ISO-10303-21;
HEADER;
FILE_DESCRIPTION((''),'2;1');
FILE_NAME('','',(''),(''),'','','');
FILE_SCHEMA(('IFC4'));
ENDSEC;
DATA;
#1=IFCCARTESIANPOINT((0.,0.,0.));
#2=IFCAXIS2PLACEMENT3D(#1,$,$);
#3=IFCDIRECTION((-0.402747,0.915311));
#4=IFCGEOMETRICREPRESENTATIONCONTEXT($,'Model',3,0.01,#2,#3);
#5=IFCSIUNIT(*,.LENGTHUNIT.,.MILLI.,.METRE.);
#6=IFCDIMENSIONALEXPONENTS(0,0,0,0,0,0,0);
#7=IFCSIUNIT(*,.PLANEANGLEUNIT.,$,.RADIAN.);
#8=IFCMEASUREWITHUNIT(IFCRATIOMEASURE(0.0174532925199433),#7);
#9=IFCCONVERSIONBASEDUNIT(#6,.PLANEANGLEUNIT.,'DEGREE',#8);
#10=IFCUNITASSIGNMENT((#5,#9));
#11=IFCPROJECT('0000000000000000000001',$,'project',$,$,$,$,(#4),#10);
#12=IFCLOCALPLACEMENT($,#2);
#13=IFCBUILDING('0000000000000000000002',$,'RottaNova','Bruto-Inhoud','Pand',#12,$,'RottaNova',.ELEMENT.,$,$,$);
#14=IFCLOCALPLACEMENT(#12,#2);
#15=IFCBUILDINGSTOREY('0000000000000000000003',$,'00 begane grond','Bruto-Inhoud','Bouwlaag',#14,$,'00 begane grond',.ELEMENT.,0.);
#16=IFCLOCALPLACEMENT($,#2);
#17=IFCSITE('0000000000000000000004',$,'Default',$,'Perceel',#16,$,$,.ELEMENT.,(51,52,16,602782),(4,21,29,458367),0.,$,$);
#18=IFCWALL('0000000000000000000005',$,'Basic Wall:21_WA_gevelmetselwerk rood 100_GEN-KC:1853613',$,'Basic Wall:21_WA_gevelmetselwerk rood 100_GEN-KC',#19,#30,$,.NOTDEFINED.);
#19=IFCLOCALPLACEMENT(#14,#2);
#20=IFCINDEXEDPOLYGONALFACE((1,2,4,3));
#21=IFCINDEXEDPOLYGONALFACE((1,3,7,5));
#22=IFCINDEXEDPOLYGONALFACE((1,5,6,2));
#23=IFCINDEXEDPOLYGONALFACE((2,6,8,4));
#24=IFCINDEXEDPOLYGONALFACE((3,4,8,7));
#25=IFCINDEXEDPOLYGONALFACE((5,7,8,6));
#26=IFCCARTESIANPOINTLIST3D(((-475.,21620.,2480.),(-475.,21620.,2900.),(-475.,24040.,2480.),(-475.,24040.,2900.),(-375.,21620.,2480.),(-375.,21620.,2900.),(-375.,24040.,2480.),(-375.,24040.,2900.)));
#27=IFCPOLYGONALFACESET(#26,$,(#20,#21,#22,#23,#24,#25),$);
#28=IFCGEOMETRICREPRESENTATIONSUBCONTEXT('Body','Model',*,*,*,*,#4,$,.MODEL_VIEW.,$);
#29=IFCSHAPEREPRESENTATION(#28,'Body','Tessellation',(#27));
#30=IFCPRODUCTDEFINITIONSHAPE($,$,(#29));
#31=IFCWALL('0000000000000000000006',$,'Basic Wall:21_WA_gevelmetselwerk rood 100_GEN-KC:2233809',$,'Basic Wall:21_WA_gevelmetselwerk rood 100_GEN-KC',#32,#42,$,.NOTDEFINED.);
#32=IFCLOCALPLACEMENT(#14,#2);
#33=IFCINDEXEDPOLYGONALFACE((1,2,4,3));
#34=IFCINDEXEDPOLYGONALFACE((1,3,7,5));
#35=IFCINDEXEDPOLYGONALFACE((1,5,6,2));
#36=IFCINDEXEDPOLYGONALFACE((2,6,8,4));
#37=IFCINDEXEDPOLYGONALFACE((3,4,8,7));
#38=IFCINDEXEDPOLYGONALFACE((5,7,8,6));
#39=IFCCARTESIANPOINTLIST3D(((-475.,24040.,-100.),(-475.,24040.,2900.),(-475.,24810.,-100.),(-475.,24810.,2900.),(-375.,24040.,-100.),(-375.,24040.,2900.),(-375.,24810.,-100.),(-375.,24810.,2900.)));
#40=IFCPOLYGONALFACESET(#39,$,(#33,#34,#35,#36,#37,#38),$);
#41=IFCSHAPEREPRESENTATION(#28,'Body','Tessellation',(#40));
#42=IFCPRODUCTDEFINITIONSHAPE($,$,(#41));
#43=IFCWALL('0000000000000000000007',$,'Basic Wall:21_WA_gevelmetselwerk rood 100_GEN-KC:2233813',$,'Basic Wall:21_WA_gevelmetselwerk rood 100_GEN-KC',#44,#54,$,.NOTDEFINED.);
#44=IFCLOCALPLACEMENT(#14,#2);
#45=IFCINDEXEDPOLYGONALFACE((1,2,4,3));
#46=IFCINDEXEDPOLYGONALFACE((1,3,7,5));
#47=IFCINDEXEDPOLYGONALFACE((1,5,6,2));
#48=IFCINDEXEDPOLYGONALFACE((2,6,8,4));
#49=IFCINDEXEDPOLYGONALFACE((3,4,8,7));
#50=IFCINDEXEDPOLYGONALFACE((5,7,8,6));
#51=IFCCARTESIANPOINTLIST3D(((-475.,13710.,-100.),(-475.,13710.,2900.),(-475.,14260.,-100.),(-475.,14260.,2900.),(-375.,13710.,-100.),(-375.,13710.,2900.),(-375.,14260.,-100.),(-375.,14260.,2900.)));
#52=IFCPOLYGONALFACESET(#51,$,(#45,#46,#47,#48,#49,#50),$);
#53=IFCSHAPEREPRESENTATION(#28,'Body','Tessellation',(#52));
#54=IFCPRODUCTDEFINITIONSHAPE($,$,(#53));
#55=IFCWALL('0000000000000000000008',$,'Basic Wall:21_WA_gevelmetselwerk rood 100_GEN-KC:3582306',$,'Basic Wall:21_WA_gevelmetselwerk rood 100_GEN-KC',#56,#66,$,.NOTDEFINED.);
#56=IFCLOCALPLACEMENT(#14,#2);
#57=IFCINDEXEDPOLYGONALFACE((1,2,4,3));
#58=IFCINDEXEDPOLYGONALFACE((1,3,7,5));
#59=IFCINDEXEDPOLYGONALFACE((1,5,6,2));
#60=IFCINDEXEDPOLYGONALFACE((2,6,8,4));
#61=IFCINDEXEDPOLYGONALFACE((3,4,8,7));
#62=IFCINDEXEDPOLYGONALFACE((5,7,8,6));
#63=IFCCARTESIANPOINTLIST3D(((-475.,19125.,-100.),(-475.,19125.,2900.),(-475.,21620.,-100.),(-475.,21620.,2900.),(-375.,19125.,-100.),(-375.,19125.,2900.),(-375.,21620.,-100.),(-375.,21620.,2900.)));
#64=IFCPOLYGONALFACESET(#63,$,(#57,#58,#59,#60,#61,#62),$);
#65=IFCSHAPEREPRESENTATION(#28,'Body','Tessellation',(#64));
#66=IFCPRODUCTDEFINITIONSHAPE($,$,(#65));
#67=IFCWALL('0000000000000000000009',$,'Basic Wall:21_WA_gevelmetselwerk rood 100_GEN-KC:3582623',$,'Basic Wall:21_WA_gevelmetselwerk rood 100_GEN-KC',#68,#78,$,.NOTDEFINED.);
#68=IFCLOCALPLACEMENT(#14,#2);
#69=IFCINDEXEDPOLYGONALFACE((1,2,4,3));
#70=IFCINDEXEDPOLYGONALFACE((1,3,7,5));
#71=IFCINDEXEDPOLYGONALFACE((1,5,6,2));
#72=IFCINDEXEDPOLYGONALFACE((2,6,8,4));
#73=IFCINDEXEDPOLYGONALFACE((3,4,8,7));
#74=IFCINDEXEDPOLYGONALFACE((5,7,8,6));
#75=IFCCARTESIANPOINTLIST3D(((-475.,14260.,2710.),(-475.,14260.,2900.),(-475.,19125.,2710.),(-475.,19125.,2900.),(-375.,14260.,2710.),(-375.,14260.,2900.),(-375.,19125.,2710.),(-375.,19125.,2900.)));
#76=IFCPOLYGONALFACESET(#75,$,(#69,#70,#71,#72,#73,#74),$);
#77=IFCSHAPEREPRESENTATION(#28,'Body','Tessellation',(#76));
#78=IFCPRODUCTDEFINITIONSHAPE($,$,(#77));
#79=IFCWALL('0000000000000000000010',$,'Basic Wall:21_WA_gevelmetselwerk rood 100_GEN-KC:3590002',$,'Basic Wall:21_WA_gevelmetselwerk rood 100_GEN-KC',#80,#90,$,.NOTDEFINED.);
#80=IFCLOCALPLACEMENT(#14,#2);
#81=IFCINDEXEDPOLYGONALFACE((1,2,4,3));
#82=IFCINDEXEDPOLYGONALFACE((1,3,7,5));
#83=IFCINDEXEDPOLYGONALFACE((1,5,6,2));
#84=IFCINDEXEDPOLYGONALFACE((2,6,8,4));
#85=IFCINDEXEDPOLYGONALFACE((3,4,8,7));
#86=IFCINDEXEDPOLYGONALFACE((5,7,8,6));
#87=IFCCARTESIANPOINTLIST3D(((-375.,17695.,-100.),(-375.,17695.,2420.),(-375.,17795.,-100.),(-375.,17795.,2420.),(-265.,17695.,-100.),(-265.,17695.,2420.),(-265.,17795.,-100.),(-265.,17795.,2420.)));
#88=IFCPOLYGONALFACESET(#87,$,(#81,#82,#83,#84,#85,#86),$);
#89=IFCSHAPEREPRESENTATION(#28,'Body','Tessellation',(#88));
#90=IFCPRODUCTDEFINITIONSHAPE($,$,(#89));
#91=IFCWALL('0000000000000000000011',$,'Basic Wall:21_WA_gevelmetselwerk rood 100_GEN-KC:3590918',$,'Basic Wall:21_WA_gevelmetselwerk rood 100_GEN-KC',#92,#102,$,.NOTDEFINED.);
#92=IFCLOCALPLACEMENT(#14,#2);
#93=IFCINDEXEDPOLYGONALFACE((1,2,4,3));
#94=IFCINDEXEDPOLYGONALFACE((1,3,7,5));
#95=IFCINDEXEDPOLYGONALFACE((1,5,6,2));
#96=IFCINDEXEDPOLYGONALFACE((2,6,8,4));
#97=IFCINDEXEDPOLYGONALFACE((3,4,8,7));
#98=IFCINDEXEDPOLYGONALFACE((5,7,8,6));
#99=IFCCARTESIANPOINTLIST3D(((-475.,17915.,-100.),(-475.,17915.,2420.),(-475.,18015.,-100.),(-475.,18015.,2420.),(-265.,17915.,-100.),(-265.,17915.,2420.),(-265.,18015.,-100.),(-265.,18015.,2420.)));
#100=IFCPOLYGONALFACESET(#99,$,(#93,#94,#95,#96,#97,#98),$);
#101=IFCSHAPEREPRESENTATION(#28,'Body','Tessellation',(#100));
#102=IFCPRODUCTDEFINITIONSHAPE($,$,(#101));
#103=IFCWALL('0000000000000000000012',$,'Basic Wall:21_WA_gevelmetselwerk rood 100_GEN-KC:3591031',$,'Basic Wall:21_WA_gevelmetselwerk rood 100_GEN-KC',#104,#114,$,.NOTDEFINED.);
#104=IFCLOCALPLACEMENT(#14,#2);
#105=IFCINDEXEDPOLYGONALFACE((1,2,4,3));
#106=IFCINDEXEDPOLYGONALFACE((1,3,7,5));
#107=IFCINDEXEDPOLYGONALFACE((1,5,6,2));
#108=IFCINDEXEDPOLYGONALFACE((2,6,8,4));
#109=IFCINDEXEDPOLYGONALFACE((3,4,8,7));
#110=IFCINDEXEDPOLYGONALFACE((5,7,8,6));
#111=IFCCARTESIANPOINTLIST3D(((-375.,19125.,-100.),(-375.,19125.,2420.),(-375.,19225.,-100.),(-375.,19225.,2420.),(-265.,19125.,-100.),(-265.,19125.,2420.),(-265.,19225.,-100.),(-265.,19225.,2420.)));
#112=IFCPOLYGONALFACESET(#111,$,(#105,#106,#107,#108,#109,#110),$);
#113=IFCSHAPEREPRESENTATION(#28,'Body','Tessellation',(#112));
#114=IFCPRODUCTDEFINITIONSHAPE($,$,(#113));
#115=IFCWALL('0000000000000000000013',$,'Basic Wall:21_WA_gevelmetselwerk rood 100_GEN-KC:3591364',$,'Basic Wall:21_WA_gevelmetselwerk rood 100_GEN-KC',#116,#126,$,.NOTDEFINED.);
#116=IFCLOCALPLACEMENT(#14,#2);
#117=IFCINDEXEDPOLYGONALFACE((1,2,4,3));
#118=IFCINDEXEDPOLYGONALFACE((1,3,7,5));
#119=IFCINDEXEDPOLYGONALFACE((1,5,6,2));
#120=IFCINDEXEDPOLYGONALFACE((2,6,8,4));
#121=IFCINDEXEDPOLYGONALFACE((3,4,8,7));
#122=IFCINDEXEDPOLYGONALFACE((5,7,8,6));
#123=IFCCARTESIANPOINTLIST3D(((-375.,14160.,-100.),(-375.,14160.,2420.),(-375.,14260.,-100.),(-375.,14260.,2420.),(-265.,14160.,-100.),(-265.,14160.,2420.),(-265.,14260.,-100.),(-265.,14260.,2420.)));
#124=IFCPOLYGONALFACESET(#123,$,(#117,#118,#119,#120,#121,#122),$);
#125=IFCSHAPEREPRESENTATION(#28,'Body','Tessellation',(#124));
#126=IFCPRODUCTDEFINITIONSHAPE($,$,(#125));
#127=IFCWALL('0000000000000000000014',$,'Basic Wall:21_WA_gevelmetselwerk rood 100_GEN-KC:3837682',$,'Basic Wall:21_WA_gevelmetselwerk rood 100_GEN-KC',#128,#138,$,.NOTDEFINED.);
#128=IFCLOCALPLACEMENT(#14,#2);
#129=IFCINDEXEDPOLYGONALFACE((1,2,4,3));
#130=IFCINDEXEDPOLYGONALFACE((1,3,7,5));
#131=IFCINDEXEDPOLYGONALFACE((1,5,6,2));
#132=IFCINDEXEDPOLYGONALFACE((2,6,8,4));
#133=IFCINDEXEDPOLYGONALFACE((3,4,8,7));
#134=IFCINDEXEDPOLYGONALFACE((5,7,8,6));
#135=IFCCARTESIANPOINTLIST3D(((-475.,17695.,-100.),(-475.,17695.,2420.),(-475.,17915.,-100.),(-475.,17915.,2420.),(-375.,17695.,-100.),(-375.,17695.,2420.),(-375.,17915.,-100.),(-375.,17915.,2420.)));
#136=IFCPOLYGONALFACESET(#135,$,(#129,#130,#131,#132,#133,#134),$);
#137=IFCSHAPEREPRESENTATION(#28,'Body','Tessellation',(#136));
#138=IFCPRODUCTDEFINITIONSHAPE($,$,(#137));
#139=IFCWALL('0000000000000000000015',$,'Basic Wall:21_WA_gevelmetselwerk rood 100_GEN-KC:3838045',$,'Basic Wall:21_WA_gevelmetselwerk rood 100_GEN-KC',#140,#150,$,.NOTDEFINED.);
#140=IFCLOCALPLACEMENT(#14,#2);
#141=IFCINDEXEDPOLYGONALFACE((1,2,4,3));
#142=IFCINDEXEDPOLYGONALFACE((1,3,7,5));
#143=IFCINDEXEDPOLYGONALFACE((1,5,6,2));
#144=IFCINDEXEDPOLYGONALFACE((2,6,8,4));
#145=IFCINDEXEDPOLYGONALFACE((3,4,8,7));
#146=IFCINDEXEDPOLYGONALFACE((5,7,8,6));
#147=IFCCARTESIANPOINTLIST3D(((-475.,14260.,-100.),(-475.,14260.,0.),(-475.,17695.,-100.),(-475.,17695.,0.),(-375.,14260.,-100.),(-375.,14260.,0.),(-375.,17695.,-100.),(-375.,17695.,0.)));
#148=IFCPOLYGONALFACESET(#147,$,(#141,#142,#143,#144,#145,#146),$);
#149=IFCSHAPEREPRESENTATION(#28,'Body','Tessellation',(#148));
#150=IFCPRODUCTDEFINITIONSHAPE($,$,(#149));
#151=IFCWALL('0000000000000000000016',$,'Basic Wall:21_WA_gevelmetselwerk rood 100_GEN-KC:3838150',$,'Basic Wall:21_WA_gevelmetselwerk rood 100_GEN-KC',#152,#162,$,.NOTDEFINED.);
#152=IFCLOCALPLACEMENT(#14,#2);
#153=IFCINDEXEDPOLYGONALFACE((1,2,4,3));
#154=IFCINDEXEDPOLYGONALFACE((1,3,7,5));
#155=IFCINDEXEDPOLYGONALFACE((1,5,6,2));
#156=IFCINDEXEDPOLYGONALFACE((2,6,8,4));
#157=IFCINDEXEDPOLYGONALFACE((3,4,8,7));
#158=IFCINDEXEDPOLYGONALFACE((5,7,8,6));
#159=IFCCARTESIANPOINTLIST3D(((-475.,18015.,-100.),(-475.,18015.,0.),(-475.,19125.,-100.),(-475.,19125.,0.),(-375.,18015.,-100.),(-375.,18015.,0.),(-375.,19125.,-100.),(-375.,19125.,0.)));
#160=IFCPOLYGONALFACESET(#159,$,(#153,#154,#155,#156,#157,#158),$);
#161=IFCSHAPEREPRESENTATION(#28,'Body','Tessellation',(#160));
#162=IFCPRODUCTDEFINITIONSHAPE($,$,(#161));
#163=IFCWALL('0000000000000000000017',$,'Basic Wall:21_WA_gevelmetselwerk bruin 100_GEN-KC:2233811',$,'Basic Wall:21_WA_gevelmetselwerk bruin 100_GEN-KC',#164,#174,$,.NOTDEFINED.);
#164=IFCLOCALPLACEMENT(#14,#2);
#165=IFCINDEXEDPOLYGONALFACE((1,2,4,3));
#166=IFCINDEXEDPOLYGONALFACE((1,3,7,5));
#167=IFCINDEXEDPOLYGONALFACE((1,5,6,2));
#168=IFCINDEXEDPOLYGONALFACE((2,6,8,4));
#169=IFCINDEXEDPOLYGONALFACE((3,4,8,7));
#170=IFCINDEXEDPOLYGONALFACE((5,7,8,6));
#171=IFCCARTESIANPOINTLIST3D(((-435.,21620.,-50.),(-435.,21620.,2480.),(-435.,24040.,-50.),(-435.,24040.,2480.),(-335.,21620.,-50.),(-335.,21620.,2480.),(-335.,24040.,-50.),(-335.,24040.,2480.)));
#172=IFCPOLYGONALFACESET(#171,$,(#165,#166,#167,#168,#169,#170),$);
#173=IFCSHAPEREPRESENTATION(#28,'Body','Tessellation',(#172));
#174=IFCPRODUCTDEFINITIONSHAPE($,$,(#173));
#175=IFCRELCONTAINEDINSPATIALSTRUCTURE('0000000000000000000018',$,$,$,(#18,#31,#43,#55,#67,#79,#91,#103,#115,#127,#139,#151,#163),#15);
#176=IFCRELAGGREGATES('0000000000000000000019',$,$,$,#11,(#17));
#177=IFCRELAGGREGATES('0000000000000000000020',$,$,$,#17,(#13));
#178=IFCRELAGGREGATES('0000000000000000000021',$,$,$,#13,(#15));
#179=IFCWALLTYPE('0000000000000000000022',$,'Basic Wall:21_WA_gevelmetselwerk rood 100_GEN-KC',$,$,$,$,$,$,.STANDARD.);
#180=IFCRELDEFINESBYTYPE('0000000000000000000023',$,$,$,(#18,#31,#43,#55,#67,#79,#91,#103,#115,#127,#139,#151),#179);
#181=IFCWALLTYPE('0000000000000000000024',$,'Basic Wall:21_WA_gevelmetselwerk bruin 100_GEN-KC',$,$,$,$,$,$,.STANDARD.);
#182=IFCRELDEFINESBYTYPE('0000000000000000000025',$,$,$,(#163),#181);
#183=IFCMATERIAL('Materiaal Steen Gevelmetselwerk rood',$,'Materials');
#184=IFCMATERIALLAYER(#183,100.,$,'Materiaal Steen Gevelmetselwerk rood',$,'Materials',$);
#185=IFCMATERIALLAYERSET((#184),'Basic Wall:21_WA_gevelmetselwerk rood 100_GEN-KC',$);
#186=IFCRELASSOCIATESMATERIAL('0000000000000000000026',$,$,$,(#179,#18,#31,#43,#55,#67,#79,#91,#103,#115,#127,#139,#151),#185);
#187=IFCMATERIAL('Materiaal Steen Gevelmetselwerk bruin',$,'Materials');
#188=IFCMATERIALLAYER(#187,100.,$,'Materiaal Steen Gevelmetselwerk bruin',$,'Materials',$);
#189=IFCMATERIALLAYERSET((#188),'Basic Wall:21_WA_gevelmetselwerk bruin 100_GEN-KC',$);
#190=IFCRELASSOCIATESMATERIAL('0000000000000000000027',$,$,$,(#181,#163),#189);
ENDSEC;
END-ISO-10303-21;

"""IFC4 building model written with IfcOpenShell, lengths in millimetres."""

from ifc_helpers import new_model, entity, si_unit, converted_unit, direction, frame, frame_2d, origin, place, context, subcontext, project, spatial, polyline, rectangle, extrude, clip, bounded_halfspace, material, layer, layer_set, type_object, element, save


model = new_model("IFC4")

# Units and contexts
model_context = context("Model", 3, precision=0.01, world=origin(), true_north=direction((-0.402747, 0.915311)))
body_context = subcontext(model_context, "Body", "Model", "MODEL_VIEW")
ifc_project = project(units=[si_unit("LENGTHUNIT", "METRE", prefix="MILLI"), converted_unit("PLANEANGLEUNIT", "DEGREE", entity("IfcRatioMeasure", 0.0174532925199433), si_unit("PLANEANGLEUNIT", "RADIAN"), dimensions=[0, 0, 0, 0, 0, 0, 0])], contexts=[model_context])

# Site, building, storey
site_placement = place(None, origin())
site = spatial("IfcSite", under=ifc_project, at=site_placement, Name="Default", ObjectType="Perceel", CompositionType="ELEMENT", RefLatitude=(51, 52, 16, 602782), RefLongitude=(4, 21, 29, 458367), RefElevation=0.0)
building_placement = place(None, origin())
building = spatial("IfcBuilding", under=site, at=building_placement, Name="RottaNova", Description="Bruto-Inhoud", ObjectType="Pand", LongName="RottaNova", CompositionType="ELEMENT")
storey_placement = place(building_placement, origin())
storey = spatial("IfcBuildingStorey", under=building, at=storey_placement, Name="00 begane grond", Description="Bruto-Inhoud", ObjectType="Bouwlaag", LongName="00 begane grond", CompositionType="ELEMENT", Elevation=0.0)

# Walls
ifc_material_1 = material(Name="Materiaal Steen Gevelmetselwerk rood", Category="Materials")
ifc_layer_1 = layer(ifc_material_1, 100.0, Name="Materiaal Steen Gevelmetselwerk rood", Category="Materials")
ifc_layer_set_1 = layer_set([ifc_layer_1], Name="Basic Wall:21_WA_gevelmetselwerk rood 100_GEN-KC")
wall_type_1 = type_object("IfcWallType", Name="Basic Wall:21_WA_gevelmetselwerk rood 100_GEN-KC", PredefinedType="STANDARD", material=ifc_layer_set_1)
wall_1_placement = place(storey_placement, frame((-425.0, 24040.0, 2480.0), z_axis=(0.0, 0.0, 1.0), x_axis=(0.0, -1.0, 0.0)))
element("IfcWall", 1, at=wall_1_placement, inside=storey, type_object=wall_type_1, material=ifc_layer_set_1, Name="Basic Wall:21_WA_gevelmetselwerk rood 100_GEN-KC:1853613", ObjectType="Basic Wall:21_WA_gevelmetselwerk rood 100_GEN-KC", PredefinedType="NOTDEFINED", context=body_context, shape_type="Clipping", body=[
    clip(extrude(rectangle(XDim=2420.0, YDim=100.0, at=frame_2d((1210.0, 0.0), x_axis=(-1.0, 0.0))), origin(), (0.0, 0.0, 1.0), 420.0), bounded_halfspace(frame((2420.0, -50.0, 420.0), z_axis=(-1.0, 0.0, 0.0), x_axis=(0.0, -1.0, 0.0)), True, frame((2420.0, -50.0, 420.0), z_axis=(-1.0, 0.0, 0.0), x_axis=(0.0, -1.0, 0.0)), polyline([(0.0, 0.0), (-30480.0, 0.0), (-30480.0, -128016.0), (0.0, -128016.0), (0.0, 0.0)]))),
])
wall_2_placement = place(storey_placement, frame((-425.0, 24040.0, -100.0), z_axis=(0.0, 0.0, 1.0), x_axis=(0.0, 1.0, 0.0)))
element("IfcWall", 2, at=wall_2_placement, inside=storey, type_object=wall_type_1, material=ifc_layer_set_1, Name="Basic Wall:21_WA_gevelmetselwerk rood 100_GEN-KC:2233809", ObjectType="Basic Wall:21_WA_gevelmetselwerk rood 100_GEN-KC", PredefinedType="NOTDEFINED", context=body_context, shape_type="SweptSolid", body=[
    extrude(rectangle(XDim=770.0, YDim=100.0, at=frame_2d((385.0, 0.0), x_axis=(-1.0, 0.0))), origin(), (0.0, 0.0, 1.0), 3000.0),
])
wall_3_placement = place(storey_placement, frame((-425.0, 13710.0, -100.0), z_axis=(0.0, 0.0, 1.0), x_axis=(0.0, 1.0, 0.0)))
element("IfcWall", 3, at=wall_3_placement, inside=storey, type_object=wall_type_1, material=ifc_layer_set_1, Name="Basic Wall:21_WA_gevelmetselwerk rood 100_GEN-KC:2233813", ObjectType="Basic Wall:21_WA_gevelmetselwerk rood 100_GEN-KC", PredefinedType="NOTDEFINED", context=body_context, shape_type="SweptSolid", body=[
    extrude(rectangle(XDim=550.0, YDim=100.0, at=frame_2d((275.0, 0.0), x_axis=(-1.0, 0.0))), origin(), (0.0, 0.0, 1.0), 3000.0),
])
wall_4_placement = place(storey_placement, frame((-425.0, 19125.0, -100.0), z_axis=(0.0, 0.0, 1.0), x_axis=(0.0, 1.0, 0.0)))
element("IfcWall", 4, at=wall_4_placement, inside=storey, type_object=wall_type_1, material=ifc_layer_set_1, Name="Basic Wall:21_WA_gevelmetselwerk rood 100_GEN-KC:3582306", ObjectType="Basic Wall:21_WA_gevelmetselwerk rood 100_GEN-KC", PredefinedType="NOTDEFINED", context=body_context, shape_type="SweptSolid", body=[
    extrude(rectangle(XDim=2495.0, YDim=100.0, at=frame_2d((1247.5, 0.0), x_axis=(-1.0, 0.0))), origin(), (0.0, 0.0, 1.0), 3000.0),
])
wall_5_placement = place(storey_placement, frame((-425.0, 14260.0, 2710.0), z_axis=(0.0, 0.0, 1.0), x_axis=(0.0, 1.0, 0.0)))
element("IfcWall", 5, at=wall_5_placement, inside=storey, type_object=wall_type_1, material=ifc_layer_set_1, Name="Basic Wall:21_WA_gevelmetselwerk rood 100_GEN-KC:3582623", ObjectType="Basic Wall:21_WA_gevelmetselwerk rood 100_GEN-KC", PredefinedType="NOTDEFINED", context=body_context, shape_type="SweptSolid", body=[
    extrude(rectangle(XDim=4865.0, YDim=100.0, at=frame_2d((2432.5, 0.0), x_axis=(-1.0, 0.0))), origin(), (0.0, 0.0, 1.0), 190.0),
])
wall_6_placement = place(storey_placement, frame((-375.0, 17745.0, -100.0)))
element("IfcWall", 6, at=wall_6_placement, inside=storey, type_object=wall_type_1, material=ifc_layer_set_1, Name="Basic Wall:21_WA_gevelmetselwerk rood 100_GEN-KC:3590002", ObjectType="Basic Wall:21_WA_gevelmetselwerk rood 100_GEN-KC", PredefinedType="NOTDEFINED", context=body_context, shape_type="SweptSolid", body=[
    extrude(rectangle(XDim=110.0, YDim=100.0, at=frame_2d((55.0, 0.0), x_axis=(-1.0, 0.0))), origin(), (0.0, 0.0, 1.0), 2520.0),
])
wall_7_placement = place(storey_placement, frame((-475.0, 17965.0, -100.0)))
element("IfcWall", 7, at=wall_7_placement, inside=storey, type_object=wall_type_1, material=ifc_layer_set_1, Name="Basic Wall:21_WA_gevelmetselwerk rood 100_GEN-KC:3590918", ObjectType="Basic Wall:21_WA_gevelmetselwerk rood 100_GEN-KC", PredefinedType="NOTDEFINED", context=body_context, shape_type="SweptSolid", body=[
    extrude(rectangle(XDim=210.0, YDim=100.0, at=frame_2d((105.0, 0.0), x_axis=(-1.0, 0.0))), origin(), (0.0, 0.0, 1.0), 2520.0),
])
wall_8_placement = place(storey_placement, frame((-375.0, 19175.0, -100.0)))
element("IfcWall", 8, at=wall_8_placement, inside=storey, type_object=wall_type_1, material=ifc_layer_set_1, Name="Basic Wall:21_WA_gevelmetselwerk rood 100_GEN-KC:3591031", ObjectType="Basic Wall:21_WA_gevelmetselwerk rood 100_GEN-KC", PredefinedType="NOTDEFINED", context=body_context, shape_type="SweptSolid", body=[
    extrude(rectangle(XDim=110.0, YDim=100.0, at=frame_2d((55.0, 0.0), x_axis=(-1.0, 0.0))), origin(), (0.0, 0.0, 1.0), 2520.0),
])
wall_9_placement = place(storey_placement, frame((-375.0, 14210.0, -100.0)))
element("IfcWall", 9, at=wall_9_placement, inside=storey, type_object=wall_type_1, material=ifc_layer_set_1, Name="Basic Wall:21_WA_gevelmetselwerk rood 100_GEN-KC:3591364", ObjectType="Basic Wall:21_WA_gevelmetselwerk rood 100_GEN-KC", PredefinedType="NOTDEFINED", context=body_context, shape_type="SweptSolid", body=[
    extrude(rectangle(XDim=110.0, YDim=100.0, at=frame_2d((55.0, 0.0), x_axis=(-1.0, 0.0))), origin(), (0.0, 0.0, 1.0), 2520.0),
])
wall_10_placement = place(storey_placement, frame((-425.0, 17695.0, -100.0), z_axis=(0.0, 0.0, 1.0), x_axis=(0.0, 1.0, 0.0)))
element("IfcWall", 10, at=wall_10_placement, inside=storey, type_object=wall_type_1, material=ifc_layer_set_1, Name="Basic Wall:21_WA_gevelmetselwerk rood 100_GEN-KC:3837682", ObjectType="Basic Wall:21_WA_gevelmetselwerk rood 100_GEN-KC", PredefinedType="NOTDEFINED", context=body_context, shape_type="SweptSolid", body=[
    extrude(rectangle(XDim=220.0, YDim=100.0, at=frame_2d((110.0, 0.0), x_axis=(-1.0, 0.0))), origin(), (0.0, 0.0, 1.0), 2520.0),
])
wall_11_placement = place(storey_placement, frame((-425.0, 14260.0, -100.0), z_axis=(0.0, 0.0, 1.0), x_axis=(0.0, 1.0, 0.0)))
element("IfcWall", 11, at=wall_11_placement, inside=storey, type_object=wall_type_1, material=ifc_layer_set_1, Name="Basic Wall:21_WA_gevelmetselwerk rood 100_GEN-KC:3838045", ObjectType="Basic Wall:21_WA_gevelmetselwerk rood 100_GEN-KC", PredefinedType="NOTDEFINED", context=body_context, shape_type="SweptSolid", body=[
    extrude(rectangle(XDim=3435.0, YDim=100.0, at=frame_2d((1717.5, 0.0), x_axis=(-1.0, 0.0))), origin(), (0.0, 0.0, 1.0), 100.0),
])
wall_12_placement = place(storey_placement, frame((-425.0, 18015.0, -100.0), z_axis=(0.0, 0.0, 1.0), x_axis=(0.0, 1.0, 0.0)))
element("IfcWall", 12, at=wall_12_placement, inside=storey, type_object=wall_type_1, material=ifc_layer_set_1, Name="Basic Wall:21_WA_gevelmetselwerk rood 100_GEN-KC:3838150", ObjectType="Basic Wall:21_WA_gevelmetselwerk rood 100_GEN-KC", PredefinedType="NOTDEFINED", context=body_context, shape_type="SweptSolid", body=[
    extrude(rectangle(XDim=1110.0, YDim=100.0, at=frame_2d((555.0, 0.0), x_axis=(-1.0, 0.0))), origin(), (0.0, 0.0, 1.0), 100.0),
])
ifc_material_2 = material(Name="Materiaal Steen Gevelmetselwerk bruin", Category="Materials")
ifc_layer_2 = layer(ifc_material_2, 100.0, Name="Materiaal Steen Gevelmetselwerk bruin", Category="Materials")
ifc_layer_set_2 = layer_set([ifc_layer_2], Name="Basic Wall:21_WA_gevelmetselwerk bruin 100_GEN-KC")
wall_type_2 = type_object("IfcWallType", Name="Basic Wall:21_WA_gevelmetselwerk bruin 100_GEN-KC", PredefinedType="STANDARD", material=ifc_layer_set_2)
wall_13_placement = place(storey_placement, frame((-385.0, 21620.0, -50.0), z_axis=(0.0, 0.0, 1.0), x_axis=(0.0, 1.0, 0.0)))
element("IfcWall", 13, at=wall_13_placement, inside=storey, type_object=wall_type_2, material=ifc_layer_set_2, Name="Basic Wall:21_WA_gevelmetselwerk bruin 100_GEN-KC:2233811", ObjectType="Basic Wall:21_WA_gevelmetselwerk bruin 100_GEN-KC", PredefinedType="NOTDEFINED", context=body_context, shape_type="SweptSolid", body=[
    extrude(rectangle(XDim=2420.0, YDim=100.0, at=frame_2d((1210.0, 0.0), x_axis=(-1.0, 0.0))), origin(), (0.0, 0.0, 1.0), 2530.0),
])

save(model, "model.ifc")
